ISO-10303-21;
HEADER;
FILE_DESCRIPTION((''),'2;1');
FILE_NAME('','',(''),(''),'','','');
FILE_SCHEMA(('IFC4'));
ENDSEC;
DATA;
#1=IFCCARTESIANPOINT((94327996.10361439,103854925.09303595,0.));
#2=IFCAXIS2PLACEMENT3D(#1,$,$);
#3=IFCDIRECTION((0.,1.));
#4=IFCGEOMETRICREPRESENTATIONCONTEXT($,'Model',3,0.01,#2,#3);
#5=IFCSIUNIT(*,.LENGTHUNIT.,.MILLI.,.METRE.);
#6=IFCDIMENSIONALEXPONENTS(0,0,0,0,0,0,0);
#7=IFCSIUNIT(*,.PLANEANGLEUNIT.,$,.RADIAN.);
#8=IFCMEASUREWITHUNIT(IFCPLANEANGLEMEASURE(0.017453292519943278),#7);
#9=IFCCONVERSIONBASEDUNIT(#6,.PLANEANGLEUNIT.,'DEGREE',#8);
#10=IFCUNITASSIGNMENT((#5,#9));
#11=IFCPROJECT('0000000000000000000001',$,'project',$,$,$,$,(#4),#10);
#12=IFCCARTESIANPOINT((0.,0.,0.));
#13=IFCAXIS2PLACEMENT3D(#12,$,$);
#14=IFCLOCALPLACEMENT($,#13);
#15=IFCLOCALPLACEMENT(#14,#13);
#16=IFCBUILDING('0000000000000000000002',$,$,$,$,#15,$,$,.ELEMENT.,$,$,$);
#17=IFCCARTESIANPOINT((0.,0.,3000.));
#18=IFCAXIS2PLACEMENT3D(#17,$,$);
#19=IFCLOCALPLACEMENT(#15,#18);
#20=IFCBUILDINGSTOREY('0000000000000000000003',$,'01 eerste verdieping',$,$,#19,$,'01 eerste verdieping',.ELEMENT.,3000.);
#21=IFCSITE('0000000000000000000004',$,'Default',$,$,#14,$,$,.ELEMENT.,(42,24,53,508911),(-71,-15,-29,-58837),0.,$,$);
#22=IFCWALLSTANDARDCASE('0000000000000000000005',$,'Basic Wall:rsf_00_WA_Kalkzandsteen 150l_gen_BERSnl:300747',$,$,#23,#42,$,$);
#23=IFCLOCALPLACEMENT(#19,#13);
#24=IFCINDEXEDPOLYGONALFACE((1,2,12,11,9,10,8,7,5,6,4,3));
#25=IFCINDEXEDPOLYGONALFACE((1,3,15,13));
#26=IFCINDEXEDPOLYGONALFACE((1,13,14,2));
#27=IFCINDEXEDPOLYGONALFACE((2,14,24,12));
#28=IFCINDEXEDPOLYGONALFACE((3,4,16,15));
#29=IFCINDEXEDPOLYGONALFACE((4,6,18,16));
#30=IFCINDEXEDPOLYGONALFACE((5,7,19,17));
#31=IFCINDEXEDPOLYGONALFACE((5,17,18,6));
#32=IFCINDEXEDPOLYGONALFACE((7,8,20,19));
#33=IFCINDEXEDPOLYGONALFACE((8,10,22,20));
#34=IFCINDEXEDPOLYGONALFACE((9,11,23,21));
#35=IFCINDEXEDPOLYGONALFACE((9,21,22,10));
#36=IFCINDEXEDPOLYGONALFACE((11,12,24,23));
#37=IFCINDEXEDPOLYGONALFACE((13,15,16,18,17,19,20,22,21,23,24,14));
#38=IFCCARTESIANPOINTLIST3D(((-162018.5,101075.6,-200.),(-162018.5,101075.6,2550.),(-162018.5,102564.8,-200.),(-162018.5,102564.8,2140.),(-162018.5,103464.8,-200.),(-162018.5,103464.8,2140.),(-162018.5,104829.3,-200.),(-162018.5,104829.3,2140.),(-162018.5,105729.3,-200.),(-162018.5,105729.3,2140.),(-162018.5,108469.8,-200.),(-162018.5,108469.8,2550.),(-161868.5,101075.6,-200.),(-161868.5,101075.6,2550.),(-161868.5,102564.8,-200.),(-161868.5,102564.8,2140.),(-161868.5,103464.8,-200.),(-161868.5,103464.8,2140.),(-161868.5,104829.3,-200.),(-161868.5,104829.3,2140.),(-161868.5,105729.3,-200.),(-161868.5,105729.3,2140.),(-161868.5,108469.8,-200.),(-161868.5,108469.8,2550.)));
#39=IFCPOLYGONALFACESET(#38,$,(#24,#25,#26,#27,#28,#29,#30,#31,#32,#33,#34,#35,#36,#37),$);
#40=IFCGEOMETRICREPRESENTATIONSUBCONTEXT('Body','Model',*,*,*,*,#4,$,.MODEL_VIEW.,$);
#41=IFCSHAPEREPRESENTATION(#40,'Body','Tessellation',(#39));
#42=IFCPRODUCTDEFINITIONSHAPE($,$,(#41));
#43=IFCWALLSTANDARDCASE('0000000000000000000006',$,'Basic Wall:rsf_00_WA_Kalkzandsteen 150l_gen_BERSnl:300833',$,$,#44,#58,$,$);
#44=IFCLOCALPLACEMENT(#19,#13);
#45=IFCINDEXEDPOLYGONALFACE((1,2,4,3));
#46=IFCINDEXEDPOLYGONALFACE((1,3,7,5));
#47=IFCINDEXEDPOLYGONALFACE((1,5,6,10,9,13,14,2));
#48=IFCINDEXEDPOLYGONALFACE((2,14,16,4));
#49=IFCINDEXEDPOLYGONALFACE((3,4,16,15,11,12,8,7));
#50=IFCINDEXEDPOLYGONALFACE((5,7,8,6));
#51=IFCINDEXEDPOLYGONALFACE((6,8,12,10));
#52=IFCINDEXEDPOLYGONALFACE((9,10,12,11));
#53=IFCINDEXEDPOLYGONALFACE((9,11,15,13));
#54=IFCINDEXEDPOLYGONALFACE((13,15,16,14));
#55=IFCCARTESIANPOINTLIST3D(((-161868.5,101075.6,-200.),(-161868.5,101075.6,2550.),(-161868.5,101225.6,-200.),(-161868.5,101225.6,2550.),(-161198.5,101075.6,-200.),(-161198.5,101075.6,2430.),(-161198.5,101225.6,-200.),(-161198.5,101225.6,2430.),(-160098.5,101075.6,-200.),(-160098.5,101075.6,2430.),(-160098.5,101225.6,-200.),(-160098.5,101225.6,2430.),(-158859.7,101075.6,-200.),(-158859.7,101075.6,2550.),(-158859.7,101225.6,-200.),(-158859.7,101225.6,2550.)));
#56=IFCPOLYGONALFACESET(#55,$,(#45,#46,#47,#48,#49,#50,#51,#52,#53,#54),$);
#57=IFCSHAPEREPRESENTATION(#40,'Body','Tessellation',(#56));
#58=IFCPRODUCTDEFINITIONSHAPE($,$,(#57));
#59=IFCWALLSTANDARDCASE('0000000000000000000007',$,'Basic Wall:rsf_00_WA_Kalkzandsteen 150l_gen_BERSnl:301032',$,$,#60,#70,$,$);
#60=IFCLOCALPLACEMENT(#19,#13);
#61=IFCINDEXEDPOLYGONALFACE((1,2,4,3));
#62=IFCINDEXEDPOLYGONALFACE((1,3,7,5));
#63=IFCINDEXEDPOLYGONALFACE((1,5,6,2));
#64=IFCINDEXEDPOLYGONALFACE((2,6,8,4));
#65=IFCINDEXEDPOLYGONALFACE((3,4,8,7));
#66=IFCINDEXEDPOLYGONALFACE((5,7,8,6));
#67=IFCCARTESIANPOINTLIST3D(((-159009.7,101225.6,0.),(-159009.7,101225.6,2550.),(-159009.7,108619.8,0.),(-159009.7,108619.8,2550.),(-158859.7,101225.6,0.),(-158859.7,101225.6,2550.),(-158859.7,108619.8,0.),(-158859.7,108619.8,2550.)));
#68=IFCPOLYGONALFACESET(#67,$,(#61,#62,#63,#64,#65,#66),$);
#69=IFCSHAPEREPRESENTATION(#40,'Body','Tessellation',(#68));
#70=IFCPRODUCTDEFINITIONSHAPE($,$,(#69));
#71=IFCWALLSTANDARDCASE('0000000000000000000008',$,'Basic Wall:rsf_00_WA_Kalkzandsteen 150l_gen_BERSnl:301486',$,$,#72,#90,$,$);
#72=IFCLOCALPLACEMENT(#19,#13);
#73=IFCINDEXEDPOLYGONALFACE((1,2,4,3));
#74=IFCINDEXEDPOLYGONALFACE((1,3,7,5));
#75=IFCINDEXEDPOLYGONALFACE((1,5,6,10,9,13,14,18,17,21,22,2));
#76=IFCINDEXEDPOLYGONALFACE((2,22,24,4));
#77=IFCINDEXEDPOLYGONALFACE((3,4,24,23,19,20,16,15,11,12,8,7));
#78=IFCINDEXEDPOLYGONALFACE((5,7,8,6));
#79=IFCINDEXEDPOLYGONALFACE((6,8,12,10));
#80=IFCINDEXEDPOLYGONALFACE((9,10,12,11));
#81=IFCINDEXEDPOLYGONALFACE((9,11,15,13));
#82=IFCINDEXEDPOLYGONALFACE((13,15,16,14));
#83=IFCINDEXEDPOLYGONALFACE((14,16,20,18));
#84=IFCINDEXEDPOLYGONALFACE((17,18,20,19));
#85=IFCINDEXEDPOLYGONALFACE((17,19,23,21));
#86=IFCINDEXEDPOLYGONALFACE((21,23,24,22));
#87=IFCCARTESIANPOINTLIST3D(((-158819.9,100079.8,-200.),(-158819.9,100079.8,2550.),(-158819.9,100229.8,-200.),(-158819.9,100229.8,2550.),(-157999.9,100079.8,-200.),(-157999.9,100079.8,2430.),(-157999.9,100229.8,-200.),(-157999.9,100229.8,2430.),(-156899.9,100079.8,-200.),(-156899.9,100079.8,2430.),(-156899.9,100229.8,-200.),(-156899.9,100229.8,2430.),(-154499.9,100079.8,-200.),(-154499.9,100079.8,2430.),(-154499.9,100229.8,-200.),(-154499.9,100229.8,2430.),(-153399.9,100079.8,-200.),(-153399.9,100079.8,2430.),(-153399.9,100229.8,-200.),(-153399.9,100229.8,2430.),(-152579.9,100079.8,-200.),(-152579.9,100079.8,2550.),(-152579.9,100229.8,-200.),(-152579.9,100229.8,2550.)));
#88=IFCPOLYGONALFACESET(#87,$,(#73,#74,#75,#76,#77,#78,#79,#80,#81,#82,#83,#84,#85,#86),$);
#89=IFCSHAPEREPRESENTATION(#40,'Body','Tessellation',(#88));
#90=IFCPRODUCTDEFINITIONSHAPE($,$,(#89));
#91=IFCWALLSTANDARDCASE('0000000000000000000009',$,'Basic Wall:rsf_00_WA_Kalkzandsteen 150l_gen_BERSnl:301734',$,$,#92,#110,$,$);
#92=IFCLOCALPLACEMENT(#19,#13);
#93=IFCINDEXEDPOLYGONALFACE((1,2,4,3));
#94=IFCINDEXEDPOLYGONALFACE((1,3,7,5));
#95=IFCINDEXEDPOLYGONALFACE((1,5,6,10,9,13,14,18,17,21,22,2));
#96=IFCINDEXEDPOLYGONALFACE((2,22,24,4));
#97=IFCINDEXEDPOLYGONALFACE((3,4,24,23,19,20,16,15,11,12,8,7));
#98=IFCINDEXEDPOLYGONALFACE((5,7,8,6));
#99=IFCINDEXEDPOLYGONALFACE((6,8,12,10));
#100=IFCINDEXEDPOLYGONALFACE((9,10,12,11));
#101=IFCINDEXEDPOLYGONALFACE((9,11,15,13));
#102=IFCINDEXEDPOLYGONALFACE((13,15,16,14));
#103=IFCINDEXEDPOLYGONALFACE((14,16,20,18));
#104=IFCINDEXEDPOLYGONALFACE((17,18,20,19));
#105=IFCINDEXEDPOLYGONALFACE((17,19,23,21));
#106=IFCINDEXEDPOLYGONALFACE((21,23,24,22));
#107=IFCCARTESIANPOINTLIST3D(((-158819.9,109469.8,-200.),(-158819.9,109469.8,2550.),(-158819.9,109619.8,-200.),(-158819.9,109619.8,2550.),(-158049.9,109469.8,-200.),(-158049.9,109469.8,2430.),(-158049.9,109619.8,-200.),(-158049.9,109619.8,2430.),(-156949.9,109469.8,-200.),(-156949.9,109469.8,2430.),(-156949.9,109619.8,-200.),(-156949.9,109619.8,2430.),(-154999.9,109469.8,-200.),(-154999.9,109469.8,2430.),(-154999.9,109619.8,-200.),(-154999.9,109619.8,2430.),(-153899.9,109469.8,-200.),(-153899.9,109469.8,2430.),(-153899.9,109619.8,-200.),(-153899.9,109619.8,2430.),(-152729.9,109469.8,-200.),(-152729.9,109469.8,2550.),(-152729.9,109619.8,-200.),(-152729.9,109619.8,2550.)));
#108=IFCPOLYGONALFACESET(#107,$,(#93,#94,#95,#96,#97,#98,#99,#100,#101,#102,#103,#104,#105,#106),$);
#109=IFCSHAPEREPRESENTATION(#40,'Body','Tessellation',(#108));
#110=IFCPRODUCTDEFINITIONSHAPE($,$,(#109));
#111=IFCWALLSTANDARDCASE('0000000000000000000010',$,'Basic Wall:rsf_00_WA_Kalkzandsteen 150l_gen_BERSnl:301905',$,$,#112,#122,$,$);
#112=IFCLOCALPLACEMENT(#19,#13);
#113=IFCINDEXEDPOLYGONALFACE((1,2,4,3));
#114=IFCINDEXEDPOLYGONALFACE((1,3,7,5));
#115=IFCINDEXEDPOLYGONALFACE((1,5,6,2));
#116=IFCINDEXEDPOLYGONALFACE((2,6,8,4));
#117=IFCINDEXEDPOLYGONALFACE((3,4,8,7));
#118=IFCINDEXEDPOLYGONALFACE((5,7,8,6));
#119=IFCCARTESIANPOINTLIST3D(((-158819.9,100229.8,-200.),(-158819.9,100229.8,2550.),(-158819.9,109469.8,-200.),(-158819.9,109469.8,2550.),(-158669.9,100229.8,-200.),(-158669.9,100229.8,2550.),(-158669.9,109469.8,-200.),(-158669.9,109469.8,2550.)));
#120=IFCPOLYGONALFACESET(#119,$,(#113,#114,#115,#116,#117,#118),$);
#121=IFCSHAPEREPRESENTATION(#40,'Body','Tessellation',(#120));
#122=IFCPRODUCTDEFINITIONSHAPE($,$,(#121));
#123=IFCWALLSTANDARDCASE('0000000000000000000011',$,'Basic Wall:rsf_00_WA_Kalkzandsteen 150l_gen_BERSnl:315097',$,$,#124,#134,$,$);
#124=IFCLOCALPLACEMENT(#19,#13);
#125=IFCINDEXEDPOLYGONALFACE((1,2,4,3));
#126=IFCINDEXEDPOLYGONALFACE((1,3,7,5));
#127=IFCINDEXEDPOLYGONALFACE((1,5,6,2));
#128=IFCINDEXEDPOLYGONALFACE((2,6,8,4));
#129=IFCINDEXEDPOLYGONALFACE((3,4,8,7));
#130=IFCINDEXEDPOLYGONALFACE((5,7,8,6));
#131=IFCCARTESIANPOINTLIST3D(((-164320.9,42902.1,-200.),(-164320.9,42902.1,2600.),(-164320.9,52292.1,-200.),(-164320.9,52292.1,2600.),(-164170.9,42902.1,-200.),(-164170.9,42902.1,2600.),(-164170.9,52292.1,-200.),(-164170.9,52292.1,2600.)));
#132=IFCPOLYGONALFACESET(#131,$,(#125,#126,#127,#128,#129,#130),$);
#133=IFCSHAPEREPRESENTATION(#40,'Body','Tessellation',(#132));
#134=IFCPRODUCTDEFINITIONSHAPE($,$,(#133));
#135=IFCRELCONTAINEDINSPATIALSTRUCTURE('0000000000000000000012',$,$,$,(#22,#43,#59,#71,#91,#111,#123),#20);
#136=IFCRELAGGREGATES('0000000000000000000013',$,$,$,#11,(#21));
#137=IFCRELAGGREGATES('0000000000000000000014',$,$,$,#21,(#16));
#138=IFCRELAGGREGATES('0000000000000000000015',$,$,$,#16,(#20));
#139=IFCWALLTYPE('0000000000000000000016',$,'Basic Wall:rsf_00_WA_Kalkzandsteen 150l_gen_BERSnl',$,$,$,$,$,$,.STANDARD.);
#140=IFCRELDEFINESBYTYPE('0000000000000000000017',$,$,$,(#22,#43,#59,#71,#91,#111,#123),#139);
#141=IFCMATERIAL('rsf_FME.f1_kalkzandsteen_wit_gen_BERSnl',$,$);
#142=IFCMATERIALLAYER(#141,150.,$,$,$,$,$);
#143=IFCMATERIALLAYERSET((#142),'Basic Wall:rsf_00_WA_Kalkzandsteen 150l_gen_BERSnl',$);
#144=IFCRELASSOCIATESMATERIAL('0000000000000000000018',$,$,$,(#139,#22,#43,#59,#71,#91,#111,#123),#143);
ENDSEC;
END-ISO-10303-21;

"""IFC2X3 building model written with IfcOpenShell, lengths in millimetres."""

from ifc_helpers import new_model, entity, si_unit, converted_unit, direction, frame, frame_2d, origin, place, context, subcontext, project, spatial, polyline, rectangle, extrude, clip, bounded_halfspace, material, layer, layer_set, layer_usage, type_object, element, save


model = new_model("IFC2X3")

# Units and contexts
model_context = context("Model", 3, precision=0.01, world=frame((94327996.10361439, 103854925.09303595, 0.0)), true_north=direction((0.0, 1.0)))
body_context = subcontext(model_context, "Body", "Model", "MODEL_VIEW")
ifc_project = project(units=[si_unit("LENGTHUNIT", "METRE", prefix="MILLI"), converted_unit("PLANEANGLEUNIT", "DEGREE", entity("IfcPlaneAngleMeasure", 0.017453292519943278), si_unit("PLANEANGLEUNIT", "RADIAN"), dimensions=[0, 0, 0, 0, 0, 0, 0])], contexts=[model_context])

# Site, building, storey
site_placement = place(None, origin())
site = spatial("IfcSite", under=ifc_project, at=site_placement, Name="Default", CompositionType="ELEMENT", RefLatitude=(42, 24, 53, 508911), RefLongitude=(-71, -15, -29, -58837), RefElevation=0.0)
building_placement = place(site_placement, origin())
building = spatial("IfcBuilding", under=site, at=building_placement, CompositionType="ELEMENT")
storey_placement = place(building_placement, frame((0.0, 0.0, 3000.0)))
storey = spatial("IfcBuildingStorey", under=building, at=storey_placement, Name="01 eerste verdieping", LongName="01 eerste verdieping", CompositionType="ELEMENT", Elevation=3000.0)

# Wall, openings
ifc_material = material(Name="rsf_FME.f1_kalkzandsteen_wit_gen_BERSnl")
ifc_layer = layer(ifc_material, 150.0)
ifc_layer_set = layer_set([ifc_layer], Name="Basic Wall:rsf_00_WA_Kalkzandsteen 150l_gen_BERSnl")
ifc_layer_usage_1 = layer_usage(ifc_layer_set, "AXIS2", "NEGATIVE", 75.0)
wall_type = type_object("IfcWallType", Name="Basic Wall:rsf_00_WA_Kalkzandsteen 150l_gen_BERSnl", PredefinedType="STANDARD", material=ifc_layer_set)
wall_1_placement = place(storey_placement, frame((-161943.5, 108469.8, -200.0), z_axis=(0.0, 0.0, 1.0), x_axis=(0.0, -1.0, 0.0)))
wall_1 = element("IfcWallStandardCase", 1, at=wall_1_placement, inside=storey, type_object=wall_type, material=ifc_layer_usage_1, Name="Basic Wall:rsf_00_WA_Kalkzandsteen 150l_gen_BERSnl:300747", context=body_context, shape_type="Clipping", body=[
    clip(extrude(rectangle(XDim=7394.1, YDim=150.0, at=frame_2d((3697.1, 0.0), x_axis=(-1.0, 0.0))), origin(), (0.0, 0.0, 1.0), 2750.0), bounded_halfspace(frame((7394.1, 75.0, 2750.0), z_axis=(0.0, 0.0, -1.0), x_axis=(-1.0, 0.0, 0.0)), True, frame((7394.1, 75.0, 2750.0)), polyline([(0.0, 0.0), (-150.0, 0.0), (-7394.1, 0.0), (-7394.1, -150.0), (-4833.7, -150.0), (-4683.7, -150.0), (-554.1, -150.0), (-404.1, -150.0), (0.0, -150.0), (0.0, 0.0)]))),
])
opening_1_placement = place(wall_1_placement, frame((108469.8, 161943.5, 200.0), z_axis=(0.0, 0.0, 1.0), x_axis=(0.0, 1.0, 0.0)))
element("IfcOpeningElement", 2, at=opening_1_placement, cuts=wall_1, ObjectType="Opening", context=body_context, shape_type="SweptSolid", body=[
    extrude(rectangle(XDim=2340.0, YDim=900.0, at=frame_2d((0.0, 0.0), x_axis=(1.0, 0.0))), frame((-163392.5, 103014.8, 970.0), z_axis=(1.0, 0.0, 0.0), x_axis=(0.0, 0.0, 1.0)), (0.0, 0.0, 1.0), 3048.0),
])
opening_2_placement = place(wall_1_placement, frame((108469.8, 161943.5, 200.0), z_axis=(0.0, 0.0, 1.0), x_axis=(0.0, 1.0, 0.0)))
element("IfcOpeningElement", 3, at=opening_2_placement, cuts=wall_1, ObjectType="Opening", context=body_context, shape_type="SweptSolid", body=[
    extrude(rectangle(XDim=2340.0, YDim=900.0, at=frame_2d((0.0, 0.0), x_axis=(1.0, 0.0))), frame((-163392.5, 105279.3, 970.0), z_axis=(1.0, 0.0, 0.0), x_axis=(0.0, 0.0, 1.0)), (0.0, 0.0, 1.0), 3048.0),
])

# Wall, opening
ifc_layer_usage_2 = layer_usage(ifc_layer_set, "AXIS2", "NEGATIVE", 75.0)
wall_2_placement = place(storey_placement, frame((-161868.5, 101150.6, -200.0)))
wall_2 = element("IfcWallStandardCase", 4, at=wall_2_placement, inside=storey, type_object=wall_type, material=ifc_layer_usage_2, Name="Basic Wall:rsf_00_WA_Kalkzandsteen 150l_gen_BERSnl:300833", context=body_context, shape_type="Clipping", body=[
    clip(extrude(rectangle(XDim=3008.8, YDim=150.0, at=frame_2d((1504.4, 0.0), x_axis=(-1.0, 0.0))), origin(), (0.0, 0.0, 1.0), 2750.0), bounded_halfspace(frame((0.0, -75.0, 2750.0), z_axis=(0.0, 0.0, -1.0), x_axis=(0.0, 1.0, 0.0)), True, frame((0.0, -75.0, 2750.0)), polyline([(0.0, 0.0), (3008.8, 0.0), (3008.8, 150.0), (2858.8, 150.0), (0.0, 150.0), (0.0, 0.0)]))),
])
opening_3_placement = place(wall_2_placement, frame((161868.5, -101150.6, 200.0)))
element("IfcOpeningElement", 5, at=opening_3_placement, cuts=wall_2, ObjectType="Opening", context=body_context, shape_type="SweptSolid", body=[
    extrude(rectangle(XDim=2630.0, YDim=1100.0, at=frame_2d((0.0, 0.0), x_axis=(0.0, 1.0))), frame((-160648.5, 99551.6, 1115.0), z_axis=(0.0, 1.0, 0.0), x_axis=(-1.0, 0.0, 0.0)), (0.0, 0.0, 1.0), 3048.0),
])

# Wall
ifc_layer_usage_3 = layer_usage(ifc_layer_set, "AXIS2", "NEGATIVE", 75.0)
wall_3_placement = place(storey_placement, frame((-158934.7, 101225.6, 0.0), z_axis=(0.0, 0.0, 1.0), x_axis=(0.0, 1.0, 0.0)))
element("IfcWallStandardCase", 6, at=wall_3_placement, inside=storey, type_object=wall_type, material=ifc_layer_usage_3, Name="Basic Wall:rsf_00_WA_Kalkzandsteen 150l_gen_BERSnl:301032", context=body_context, shape_type="Clipping", body=[
    clip(extrude(rectangle(XDim=7394.1, YDim=150.0, at=frame_2d((3697.1, 0.0), x_axis=(-1.0, 0.0))), origin(), (0.0, 0.0, 1.0), 2550.0), bounded_halfspace(frame((0.0, -75.0, 2550.0), z_axis=(0.0, 0.0, -1.0), x_axis=(1.0, 0.0, 0.0)), True, frame((0.0, -75.0, 2550.0)), polyline([(0.0, 0.0), (7394.1, 0.0), (7394.1, 150.0), (7244.1, 150.0), (0.0, 150.0), (0.0, 0.0)]))),
])

# Walls, openings
ifc_layer_usage_4 = layer_usage(ifc_layer_set, "AXIS2", "NEGATIVE", 75.0)
wall_4_placement = place(storey_placement, frame((-158819.9, 100154.8, -200.0)))
wall_4 = element("IfcWallStandardCase", 7, at=wall_4_placement, inside=storey, type_object=wall_type, material=ifc_layer_usage_4, Name="Basic Wall:rsf_00_WA_Kalkzandsteen 150l_gen_BERSnl:301486", context=body_context, shape_type="Clipping", body=[
    clip(extrude(rectangle(XDim=6240.0, YDim=150.0, at=frame_2d((3120.0, 0.0), x_axis=(1.0, 0.0))), origin(), (0.0, 0.0, 1.0), 2750.0), bounded_halfspace(frame((0.0, -75.0, 2750.0), z_axis=(0.0, 0.0, -1.0), x_axis=(0.0, 1.0, 0.0)), True, frame((0.0, -75.0, 2750.0)), polyline([(0.0, 0.0), (6240.0, 0.0), (6240.0, 150.0), (6090.0, 150.0), (3240.0, 150.0), (3090.0, 150.0), (150.0, 150.0), (0.0, 150.0), (0.0, 0.0)]))),
])
opening_4_placement = place(wall_4_placement, frame((158819.9, -100154.8, 200.0)))
element("IfcOpeningElement", 8, at=opening_4_placement, cuts=wall_4, ObjectType="Opening", context=body_context, shape_type="SweptSolid", body=[
    extrude(rectangle(XDim=2630.0, YDim=1100.0, at=frame_2d((0.0, 0.0), x_axis=(1.0, 0.0))), frame((-157449.9, 98705.8, 1115.0), z_axis=(0.0, 1.0, 0.0), x_axis=(0.0, 0.0, 1.0)), (0.0, 0.0, 1.0), 3048.0),
])
opening_5_placement = place(wall_4_placement, frame((158819.9, -100154.8, 200.0)))
element("IfcOpeningElement", 9, at=opening_5_placement, cuts=wall_4, ObjectType="Opening", context=body_context, shape_type="SweptSolid", body=[
    extrude(rectangle(XDim=2630.0, YDim=1100.0, at=frame_2d((0.0, 0.0), x_axis=(1.0, 0.0))), frame((-153949.9, 98705.8, 1115.0), z_axis=(0.0, 1.0, 0.0), x_axis=(0.0, 0.0, 1.0)), (0.0, 0.0, 1.0), 3048.0),
])
ifc_layer_usage_5 = layer_usage(ifc_layer_set, "AXIS2", "NEGATIVE", 75.0)
wall_5_placement = place(storey_placement, frame((-152729.9, 109544.8, -200.0), z_axis=(0.0, 0.0, 1.0), x_axis=(-1.0, 0.0, 0.0)))
wall_5 = element("IfcWallStandardCase", 10, at=wall_5_placement, inside=storey, type_object=wall_type, material=ifc_layer_usage_5, Name="Basic Wall:rsf_00_WA_Kalkzandsteen 150l_gen_BERSnl:301734", context=body_context, shape_type="Clipping", body=[
    clip(extrude(rectangle(XDim=6090.0, YDim=150.0, at=frame_2d((3045.0, 0.0), x_axis=(-1.0, 0.0))), origin(), (0.0, 0.0, 1.0), 2750.0), bounded_halfspace(frame((0.0, -75.0, 2750.0), z_axis=(0.0, 0.0, -1.0), x_axis=(0.0, -1.0, 0.0)), True, frame((0.0, -75.0, 2750.0)), polyline([(0.0, 0.0), (6090.0, 0.0), (6090.0, 150.0), (5940.0, 150.0), (3000.0, 150.0), (2850.0, 150.0), (0.0, 150.0), (0.0, 0.0)]))),
])
opening_6_placement = place(wall_5_placement, frame((-152729.9, 109544.8, 200.0), z_axis=(0.0, 0.0, 1.0), x_axis=(-1.0, 0.0, 0.0)))
element("IfcOpeningElement", 11, at=opening_6_placement, cuts=wall_5, ObjectType="Opening", context=body_context, shape_type="SweptSolid", body=[
    extrude(rectangle(XDim=2630.0, YDim=1100.0, at=frame_2d((0.0, 0.0), x_axis=(0.0, 1.0))), frame((-154449.9, 111143.8, 1115.0), z_axis=(0.0, -1.0, 0.0), x_axis=(1.0, 0.0, 0.0)), (0.0, 0.0, 1.0), 3048.0),
])
opening_7_placement = place(wall_5_placement, frame((-152729.9, 109544.8, 200.0), z_axis=(0.0, 0.0, 1.0), x_axis=(-1.0, 0.0, 0.0)))
element("IfcOpeningElement", 12, at=opening_7_placement, cuts=wall_5, ObjectType="Opening", context=body_context, shape_type="SweptSolid", body=[
    extrude(rectangle(XDim=2630.0, YDim=1100.0, at=frame_2d((0.0, 0.0), x_axis=(0.0, 1.0))), frame((-157499.9, 111143.8, 1115.0), z_axis=(0.0, -1.0, 0.0), x_axis=(1.0, 0.0, 0.0)), (0.0, 0.0, 1.0), 3048.0),
])

# Walls
ifc_layer_usage_6 = layer_usage(ifc_layer_set, "AXIS2", "NEGATIVE", 75.0)
wall_6_placement = place(storey_placement, frame((-158744.9, 109469.8, -200.0), z_axis=(0.0, 0.0, 1.0), x_axis=(0.0, -1.0, 0.0)))
element("IfcWallStandardCase", 13, at=wall_6_placement, inside=storey, type_object=wall_type, material=ifc_layer_usage_6, Name="Basic Wall:rsf_00_WA_Kalkzandsteen 150l_gen_BERSnl:301905", context=body_context, shape_type="Clipping", body=[
    clip(extrude(rectangle(XDim=9240.0, YDim=150.0, at=frame_2d((4620.0, 0.0), x_axis=(-1.0, 0.0))), origin(), (0.0, 0.0, 1.0), 2750.0), bounded_halfspace(frame((0.0, -75.0, 2750.0), z_axis=(0.0, 0.0, -1.0), x_axis=(-1.0, 0.0, 0.0)), True, frame((0.0, -75.0, 2750.0)), polyline([(0.0, 0.0), (850.0, 0.0), (8394.1, 0.0), (9240.0, 0.0), (9240.0, 150.0), (0.0, 150.0), (0.0, 0.0)]))),
])
ifc_layer_usage_7 = layer_usage(ifc_layer_set, "AXIS2", "NEGATIVE", 75.0)
wall_7_placement = place(storey_placement, frame((-164245.9, 42902.1, -200.0), z_axis=(0.0, 0.0, 1.0), x_axis=(0.0, 1.0, 0.0)))
element("IfcWallStandardCase", 14, at=wall_7_placement, inside=storey, type_object=wall_type, material=ifc_layer_usage_7, Name="Basic Wall:rsf_00_WA_Kalkzandsteen 150l_gen_BERSnl:315097", context=body_context, shape_type="Clipping", body=[
    clip(extrude(rectangle(XDim=9390.0, YDim=150.0, at=frame_2d((4695.0, 0.0), x_axis=(-1.0, 0.0))), origin(), (0.0, 0.0, 1.0), 2800.0), bounded_halfspace(frame((0.0, -75.0, 2800.0), z_axis=(0.0, 0.0, -1.0), x_axis=(1.0, 0.0, 0.0)), True, frame((0.0, -75.0, 2800.0)), polyline([(0.0, 0.0), (9390.0, 0.0), (9390.0, 150.0), (9240.0, 150.0), (0.0, 150.0), (0.0, 0.0)]))),
])

save(model, "model.ifc")
